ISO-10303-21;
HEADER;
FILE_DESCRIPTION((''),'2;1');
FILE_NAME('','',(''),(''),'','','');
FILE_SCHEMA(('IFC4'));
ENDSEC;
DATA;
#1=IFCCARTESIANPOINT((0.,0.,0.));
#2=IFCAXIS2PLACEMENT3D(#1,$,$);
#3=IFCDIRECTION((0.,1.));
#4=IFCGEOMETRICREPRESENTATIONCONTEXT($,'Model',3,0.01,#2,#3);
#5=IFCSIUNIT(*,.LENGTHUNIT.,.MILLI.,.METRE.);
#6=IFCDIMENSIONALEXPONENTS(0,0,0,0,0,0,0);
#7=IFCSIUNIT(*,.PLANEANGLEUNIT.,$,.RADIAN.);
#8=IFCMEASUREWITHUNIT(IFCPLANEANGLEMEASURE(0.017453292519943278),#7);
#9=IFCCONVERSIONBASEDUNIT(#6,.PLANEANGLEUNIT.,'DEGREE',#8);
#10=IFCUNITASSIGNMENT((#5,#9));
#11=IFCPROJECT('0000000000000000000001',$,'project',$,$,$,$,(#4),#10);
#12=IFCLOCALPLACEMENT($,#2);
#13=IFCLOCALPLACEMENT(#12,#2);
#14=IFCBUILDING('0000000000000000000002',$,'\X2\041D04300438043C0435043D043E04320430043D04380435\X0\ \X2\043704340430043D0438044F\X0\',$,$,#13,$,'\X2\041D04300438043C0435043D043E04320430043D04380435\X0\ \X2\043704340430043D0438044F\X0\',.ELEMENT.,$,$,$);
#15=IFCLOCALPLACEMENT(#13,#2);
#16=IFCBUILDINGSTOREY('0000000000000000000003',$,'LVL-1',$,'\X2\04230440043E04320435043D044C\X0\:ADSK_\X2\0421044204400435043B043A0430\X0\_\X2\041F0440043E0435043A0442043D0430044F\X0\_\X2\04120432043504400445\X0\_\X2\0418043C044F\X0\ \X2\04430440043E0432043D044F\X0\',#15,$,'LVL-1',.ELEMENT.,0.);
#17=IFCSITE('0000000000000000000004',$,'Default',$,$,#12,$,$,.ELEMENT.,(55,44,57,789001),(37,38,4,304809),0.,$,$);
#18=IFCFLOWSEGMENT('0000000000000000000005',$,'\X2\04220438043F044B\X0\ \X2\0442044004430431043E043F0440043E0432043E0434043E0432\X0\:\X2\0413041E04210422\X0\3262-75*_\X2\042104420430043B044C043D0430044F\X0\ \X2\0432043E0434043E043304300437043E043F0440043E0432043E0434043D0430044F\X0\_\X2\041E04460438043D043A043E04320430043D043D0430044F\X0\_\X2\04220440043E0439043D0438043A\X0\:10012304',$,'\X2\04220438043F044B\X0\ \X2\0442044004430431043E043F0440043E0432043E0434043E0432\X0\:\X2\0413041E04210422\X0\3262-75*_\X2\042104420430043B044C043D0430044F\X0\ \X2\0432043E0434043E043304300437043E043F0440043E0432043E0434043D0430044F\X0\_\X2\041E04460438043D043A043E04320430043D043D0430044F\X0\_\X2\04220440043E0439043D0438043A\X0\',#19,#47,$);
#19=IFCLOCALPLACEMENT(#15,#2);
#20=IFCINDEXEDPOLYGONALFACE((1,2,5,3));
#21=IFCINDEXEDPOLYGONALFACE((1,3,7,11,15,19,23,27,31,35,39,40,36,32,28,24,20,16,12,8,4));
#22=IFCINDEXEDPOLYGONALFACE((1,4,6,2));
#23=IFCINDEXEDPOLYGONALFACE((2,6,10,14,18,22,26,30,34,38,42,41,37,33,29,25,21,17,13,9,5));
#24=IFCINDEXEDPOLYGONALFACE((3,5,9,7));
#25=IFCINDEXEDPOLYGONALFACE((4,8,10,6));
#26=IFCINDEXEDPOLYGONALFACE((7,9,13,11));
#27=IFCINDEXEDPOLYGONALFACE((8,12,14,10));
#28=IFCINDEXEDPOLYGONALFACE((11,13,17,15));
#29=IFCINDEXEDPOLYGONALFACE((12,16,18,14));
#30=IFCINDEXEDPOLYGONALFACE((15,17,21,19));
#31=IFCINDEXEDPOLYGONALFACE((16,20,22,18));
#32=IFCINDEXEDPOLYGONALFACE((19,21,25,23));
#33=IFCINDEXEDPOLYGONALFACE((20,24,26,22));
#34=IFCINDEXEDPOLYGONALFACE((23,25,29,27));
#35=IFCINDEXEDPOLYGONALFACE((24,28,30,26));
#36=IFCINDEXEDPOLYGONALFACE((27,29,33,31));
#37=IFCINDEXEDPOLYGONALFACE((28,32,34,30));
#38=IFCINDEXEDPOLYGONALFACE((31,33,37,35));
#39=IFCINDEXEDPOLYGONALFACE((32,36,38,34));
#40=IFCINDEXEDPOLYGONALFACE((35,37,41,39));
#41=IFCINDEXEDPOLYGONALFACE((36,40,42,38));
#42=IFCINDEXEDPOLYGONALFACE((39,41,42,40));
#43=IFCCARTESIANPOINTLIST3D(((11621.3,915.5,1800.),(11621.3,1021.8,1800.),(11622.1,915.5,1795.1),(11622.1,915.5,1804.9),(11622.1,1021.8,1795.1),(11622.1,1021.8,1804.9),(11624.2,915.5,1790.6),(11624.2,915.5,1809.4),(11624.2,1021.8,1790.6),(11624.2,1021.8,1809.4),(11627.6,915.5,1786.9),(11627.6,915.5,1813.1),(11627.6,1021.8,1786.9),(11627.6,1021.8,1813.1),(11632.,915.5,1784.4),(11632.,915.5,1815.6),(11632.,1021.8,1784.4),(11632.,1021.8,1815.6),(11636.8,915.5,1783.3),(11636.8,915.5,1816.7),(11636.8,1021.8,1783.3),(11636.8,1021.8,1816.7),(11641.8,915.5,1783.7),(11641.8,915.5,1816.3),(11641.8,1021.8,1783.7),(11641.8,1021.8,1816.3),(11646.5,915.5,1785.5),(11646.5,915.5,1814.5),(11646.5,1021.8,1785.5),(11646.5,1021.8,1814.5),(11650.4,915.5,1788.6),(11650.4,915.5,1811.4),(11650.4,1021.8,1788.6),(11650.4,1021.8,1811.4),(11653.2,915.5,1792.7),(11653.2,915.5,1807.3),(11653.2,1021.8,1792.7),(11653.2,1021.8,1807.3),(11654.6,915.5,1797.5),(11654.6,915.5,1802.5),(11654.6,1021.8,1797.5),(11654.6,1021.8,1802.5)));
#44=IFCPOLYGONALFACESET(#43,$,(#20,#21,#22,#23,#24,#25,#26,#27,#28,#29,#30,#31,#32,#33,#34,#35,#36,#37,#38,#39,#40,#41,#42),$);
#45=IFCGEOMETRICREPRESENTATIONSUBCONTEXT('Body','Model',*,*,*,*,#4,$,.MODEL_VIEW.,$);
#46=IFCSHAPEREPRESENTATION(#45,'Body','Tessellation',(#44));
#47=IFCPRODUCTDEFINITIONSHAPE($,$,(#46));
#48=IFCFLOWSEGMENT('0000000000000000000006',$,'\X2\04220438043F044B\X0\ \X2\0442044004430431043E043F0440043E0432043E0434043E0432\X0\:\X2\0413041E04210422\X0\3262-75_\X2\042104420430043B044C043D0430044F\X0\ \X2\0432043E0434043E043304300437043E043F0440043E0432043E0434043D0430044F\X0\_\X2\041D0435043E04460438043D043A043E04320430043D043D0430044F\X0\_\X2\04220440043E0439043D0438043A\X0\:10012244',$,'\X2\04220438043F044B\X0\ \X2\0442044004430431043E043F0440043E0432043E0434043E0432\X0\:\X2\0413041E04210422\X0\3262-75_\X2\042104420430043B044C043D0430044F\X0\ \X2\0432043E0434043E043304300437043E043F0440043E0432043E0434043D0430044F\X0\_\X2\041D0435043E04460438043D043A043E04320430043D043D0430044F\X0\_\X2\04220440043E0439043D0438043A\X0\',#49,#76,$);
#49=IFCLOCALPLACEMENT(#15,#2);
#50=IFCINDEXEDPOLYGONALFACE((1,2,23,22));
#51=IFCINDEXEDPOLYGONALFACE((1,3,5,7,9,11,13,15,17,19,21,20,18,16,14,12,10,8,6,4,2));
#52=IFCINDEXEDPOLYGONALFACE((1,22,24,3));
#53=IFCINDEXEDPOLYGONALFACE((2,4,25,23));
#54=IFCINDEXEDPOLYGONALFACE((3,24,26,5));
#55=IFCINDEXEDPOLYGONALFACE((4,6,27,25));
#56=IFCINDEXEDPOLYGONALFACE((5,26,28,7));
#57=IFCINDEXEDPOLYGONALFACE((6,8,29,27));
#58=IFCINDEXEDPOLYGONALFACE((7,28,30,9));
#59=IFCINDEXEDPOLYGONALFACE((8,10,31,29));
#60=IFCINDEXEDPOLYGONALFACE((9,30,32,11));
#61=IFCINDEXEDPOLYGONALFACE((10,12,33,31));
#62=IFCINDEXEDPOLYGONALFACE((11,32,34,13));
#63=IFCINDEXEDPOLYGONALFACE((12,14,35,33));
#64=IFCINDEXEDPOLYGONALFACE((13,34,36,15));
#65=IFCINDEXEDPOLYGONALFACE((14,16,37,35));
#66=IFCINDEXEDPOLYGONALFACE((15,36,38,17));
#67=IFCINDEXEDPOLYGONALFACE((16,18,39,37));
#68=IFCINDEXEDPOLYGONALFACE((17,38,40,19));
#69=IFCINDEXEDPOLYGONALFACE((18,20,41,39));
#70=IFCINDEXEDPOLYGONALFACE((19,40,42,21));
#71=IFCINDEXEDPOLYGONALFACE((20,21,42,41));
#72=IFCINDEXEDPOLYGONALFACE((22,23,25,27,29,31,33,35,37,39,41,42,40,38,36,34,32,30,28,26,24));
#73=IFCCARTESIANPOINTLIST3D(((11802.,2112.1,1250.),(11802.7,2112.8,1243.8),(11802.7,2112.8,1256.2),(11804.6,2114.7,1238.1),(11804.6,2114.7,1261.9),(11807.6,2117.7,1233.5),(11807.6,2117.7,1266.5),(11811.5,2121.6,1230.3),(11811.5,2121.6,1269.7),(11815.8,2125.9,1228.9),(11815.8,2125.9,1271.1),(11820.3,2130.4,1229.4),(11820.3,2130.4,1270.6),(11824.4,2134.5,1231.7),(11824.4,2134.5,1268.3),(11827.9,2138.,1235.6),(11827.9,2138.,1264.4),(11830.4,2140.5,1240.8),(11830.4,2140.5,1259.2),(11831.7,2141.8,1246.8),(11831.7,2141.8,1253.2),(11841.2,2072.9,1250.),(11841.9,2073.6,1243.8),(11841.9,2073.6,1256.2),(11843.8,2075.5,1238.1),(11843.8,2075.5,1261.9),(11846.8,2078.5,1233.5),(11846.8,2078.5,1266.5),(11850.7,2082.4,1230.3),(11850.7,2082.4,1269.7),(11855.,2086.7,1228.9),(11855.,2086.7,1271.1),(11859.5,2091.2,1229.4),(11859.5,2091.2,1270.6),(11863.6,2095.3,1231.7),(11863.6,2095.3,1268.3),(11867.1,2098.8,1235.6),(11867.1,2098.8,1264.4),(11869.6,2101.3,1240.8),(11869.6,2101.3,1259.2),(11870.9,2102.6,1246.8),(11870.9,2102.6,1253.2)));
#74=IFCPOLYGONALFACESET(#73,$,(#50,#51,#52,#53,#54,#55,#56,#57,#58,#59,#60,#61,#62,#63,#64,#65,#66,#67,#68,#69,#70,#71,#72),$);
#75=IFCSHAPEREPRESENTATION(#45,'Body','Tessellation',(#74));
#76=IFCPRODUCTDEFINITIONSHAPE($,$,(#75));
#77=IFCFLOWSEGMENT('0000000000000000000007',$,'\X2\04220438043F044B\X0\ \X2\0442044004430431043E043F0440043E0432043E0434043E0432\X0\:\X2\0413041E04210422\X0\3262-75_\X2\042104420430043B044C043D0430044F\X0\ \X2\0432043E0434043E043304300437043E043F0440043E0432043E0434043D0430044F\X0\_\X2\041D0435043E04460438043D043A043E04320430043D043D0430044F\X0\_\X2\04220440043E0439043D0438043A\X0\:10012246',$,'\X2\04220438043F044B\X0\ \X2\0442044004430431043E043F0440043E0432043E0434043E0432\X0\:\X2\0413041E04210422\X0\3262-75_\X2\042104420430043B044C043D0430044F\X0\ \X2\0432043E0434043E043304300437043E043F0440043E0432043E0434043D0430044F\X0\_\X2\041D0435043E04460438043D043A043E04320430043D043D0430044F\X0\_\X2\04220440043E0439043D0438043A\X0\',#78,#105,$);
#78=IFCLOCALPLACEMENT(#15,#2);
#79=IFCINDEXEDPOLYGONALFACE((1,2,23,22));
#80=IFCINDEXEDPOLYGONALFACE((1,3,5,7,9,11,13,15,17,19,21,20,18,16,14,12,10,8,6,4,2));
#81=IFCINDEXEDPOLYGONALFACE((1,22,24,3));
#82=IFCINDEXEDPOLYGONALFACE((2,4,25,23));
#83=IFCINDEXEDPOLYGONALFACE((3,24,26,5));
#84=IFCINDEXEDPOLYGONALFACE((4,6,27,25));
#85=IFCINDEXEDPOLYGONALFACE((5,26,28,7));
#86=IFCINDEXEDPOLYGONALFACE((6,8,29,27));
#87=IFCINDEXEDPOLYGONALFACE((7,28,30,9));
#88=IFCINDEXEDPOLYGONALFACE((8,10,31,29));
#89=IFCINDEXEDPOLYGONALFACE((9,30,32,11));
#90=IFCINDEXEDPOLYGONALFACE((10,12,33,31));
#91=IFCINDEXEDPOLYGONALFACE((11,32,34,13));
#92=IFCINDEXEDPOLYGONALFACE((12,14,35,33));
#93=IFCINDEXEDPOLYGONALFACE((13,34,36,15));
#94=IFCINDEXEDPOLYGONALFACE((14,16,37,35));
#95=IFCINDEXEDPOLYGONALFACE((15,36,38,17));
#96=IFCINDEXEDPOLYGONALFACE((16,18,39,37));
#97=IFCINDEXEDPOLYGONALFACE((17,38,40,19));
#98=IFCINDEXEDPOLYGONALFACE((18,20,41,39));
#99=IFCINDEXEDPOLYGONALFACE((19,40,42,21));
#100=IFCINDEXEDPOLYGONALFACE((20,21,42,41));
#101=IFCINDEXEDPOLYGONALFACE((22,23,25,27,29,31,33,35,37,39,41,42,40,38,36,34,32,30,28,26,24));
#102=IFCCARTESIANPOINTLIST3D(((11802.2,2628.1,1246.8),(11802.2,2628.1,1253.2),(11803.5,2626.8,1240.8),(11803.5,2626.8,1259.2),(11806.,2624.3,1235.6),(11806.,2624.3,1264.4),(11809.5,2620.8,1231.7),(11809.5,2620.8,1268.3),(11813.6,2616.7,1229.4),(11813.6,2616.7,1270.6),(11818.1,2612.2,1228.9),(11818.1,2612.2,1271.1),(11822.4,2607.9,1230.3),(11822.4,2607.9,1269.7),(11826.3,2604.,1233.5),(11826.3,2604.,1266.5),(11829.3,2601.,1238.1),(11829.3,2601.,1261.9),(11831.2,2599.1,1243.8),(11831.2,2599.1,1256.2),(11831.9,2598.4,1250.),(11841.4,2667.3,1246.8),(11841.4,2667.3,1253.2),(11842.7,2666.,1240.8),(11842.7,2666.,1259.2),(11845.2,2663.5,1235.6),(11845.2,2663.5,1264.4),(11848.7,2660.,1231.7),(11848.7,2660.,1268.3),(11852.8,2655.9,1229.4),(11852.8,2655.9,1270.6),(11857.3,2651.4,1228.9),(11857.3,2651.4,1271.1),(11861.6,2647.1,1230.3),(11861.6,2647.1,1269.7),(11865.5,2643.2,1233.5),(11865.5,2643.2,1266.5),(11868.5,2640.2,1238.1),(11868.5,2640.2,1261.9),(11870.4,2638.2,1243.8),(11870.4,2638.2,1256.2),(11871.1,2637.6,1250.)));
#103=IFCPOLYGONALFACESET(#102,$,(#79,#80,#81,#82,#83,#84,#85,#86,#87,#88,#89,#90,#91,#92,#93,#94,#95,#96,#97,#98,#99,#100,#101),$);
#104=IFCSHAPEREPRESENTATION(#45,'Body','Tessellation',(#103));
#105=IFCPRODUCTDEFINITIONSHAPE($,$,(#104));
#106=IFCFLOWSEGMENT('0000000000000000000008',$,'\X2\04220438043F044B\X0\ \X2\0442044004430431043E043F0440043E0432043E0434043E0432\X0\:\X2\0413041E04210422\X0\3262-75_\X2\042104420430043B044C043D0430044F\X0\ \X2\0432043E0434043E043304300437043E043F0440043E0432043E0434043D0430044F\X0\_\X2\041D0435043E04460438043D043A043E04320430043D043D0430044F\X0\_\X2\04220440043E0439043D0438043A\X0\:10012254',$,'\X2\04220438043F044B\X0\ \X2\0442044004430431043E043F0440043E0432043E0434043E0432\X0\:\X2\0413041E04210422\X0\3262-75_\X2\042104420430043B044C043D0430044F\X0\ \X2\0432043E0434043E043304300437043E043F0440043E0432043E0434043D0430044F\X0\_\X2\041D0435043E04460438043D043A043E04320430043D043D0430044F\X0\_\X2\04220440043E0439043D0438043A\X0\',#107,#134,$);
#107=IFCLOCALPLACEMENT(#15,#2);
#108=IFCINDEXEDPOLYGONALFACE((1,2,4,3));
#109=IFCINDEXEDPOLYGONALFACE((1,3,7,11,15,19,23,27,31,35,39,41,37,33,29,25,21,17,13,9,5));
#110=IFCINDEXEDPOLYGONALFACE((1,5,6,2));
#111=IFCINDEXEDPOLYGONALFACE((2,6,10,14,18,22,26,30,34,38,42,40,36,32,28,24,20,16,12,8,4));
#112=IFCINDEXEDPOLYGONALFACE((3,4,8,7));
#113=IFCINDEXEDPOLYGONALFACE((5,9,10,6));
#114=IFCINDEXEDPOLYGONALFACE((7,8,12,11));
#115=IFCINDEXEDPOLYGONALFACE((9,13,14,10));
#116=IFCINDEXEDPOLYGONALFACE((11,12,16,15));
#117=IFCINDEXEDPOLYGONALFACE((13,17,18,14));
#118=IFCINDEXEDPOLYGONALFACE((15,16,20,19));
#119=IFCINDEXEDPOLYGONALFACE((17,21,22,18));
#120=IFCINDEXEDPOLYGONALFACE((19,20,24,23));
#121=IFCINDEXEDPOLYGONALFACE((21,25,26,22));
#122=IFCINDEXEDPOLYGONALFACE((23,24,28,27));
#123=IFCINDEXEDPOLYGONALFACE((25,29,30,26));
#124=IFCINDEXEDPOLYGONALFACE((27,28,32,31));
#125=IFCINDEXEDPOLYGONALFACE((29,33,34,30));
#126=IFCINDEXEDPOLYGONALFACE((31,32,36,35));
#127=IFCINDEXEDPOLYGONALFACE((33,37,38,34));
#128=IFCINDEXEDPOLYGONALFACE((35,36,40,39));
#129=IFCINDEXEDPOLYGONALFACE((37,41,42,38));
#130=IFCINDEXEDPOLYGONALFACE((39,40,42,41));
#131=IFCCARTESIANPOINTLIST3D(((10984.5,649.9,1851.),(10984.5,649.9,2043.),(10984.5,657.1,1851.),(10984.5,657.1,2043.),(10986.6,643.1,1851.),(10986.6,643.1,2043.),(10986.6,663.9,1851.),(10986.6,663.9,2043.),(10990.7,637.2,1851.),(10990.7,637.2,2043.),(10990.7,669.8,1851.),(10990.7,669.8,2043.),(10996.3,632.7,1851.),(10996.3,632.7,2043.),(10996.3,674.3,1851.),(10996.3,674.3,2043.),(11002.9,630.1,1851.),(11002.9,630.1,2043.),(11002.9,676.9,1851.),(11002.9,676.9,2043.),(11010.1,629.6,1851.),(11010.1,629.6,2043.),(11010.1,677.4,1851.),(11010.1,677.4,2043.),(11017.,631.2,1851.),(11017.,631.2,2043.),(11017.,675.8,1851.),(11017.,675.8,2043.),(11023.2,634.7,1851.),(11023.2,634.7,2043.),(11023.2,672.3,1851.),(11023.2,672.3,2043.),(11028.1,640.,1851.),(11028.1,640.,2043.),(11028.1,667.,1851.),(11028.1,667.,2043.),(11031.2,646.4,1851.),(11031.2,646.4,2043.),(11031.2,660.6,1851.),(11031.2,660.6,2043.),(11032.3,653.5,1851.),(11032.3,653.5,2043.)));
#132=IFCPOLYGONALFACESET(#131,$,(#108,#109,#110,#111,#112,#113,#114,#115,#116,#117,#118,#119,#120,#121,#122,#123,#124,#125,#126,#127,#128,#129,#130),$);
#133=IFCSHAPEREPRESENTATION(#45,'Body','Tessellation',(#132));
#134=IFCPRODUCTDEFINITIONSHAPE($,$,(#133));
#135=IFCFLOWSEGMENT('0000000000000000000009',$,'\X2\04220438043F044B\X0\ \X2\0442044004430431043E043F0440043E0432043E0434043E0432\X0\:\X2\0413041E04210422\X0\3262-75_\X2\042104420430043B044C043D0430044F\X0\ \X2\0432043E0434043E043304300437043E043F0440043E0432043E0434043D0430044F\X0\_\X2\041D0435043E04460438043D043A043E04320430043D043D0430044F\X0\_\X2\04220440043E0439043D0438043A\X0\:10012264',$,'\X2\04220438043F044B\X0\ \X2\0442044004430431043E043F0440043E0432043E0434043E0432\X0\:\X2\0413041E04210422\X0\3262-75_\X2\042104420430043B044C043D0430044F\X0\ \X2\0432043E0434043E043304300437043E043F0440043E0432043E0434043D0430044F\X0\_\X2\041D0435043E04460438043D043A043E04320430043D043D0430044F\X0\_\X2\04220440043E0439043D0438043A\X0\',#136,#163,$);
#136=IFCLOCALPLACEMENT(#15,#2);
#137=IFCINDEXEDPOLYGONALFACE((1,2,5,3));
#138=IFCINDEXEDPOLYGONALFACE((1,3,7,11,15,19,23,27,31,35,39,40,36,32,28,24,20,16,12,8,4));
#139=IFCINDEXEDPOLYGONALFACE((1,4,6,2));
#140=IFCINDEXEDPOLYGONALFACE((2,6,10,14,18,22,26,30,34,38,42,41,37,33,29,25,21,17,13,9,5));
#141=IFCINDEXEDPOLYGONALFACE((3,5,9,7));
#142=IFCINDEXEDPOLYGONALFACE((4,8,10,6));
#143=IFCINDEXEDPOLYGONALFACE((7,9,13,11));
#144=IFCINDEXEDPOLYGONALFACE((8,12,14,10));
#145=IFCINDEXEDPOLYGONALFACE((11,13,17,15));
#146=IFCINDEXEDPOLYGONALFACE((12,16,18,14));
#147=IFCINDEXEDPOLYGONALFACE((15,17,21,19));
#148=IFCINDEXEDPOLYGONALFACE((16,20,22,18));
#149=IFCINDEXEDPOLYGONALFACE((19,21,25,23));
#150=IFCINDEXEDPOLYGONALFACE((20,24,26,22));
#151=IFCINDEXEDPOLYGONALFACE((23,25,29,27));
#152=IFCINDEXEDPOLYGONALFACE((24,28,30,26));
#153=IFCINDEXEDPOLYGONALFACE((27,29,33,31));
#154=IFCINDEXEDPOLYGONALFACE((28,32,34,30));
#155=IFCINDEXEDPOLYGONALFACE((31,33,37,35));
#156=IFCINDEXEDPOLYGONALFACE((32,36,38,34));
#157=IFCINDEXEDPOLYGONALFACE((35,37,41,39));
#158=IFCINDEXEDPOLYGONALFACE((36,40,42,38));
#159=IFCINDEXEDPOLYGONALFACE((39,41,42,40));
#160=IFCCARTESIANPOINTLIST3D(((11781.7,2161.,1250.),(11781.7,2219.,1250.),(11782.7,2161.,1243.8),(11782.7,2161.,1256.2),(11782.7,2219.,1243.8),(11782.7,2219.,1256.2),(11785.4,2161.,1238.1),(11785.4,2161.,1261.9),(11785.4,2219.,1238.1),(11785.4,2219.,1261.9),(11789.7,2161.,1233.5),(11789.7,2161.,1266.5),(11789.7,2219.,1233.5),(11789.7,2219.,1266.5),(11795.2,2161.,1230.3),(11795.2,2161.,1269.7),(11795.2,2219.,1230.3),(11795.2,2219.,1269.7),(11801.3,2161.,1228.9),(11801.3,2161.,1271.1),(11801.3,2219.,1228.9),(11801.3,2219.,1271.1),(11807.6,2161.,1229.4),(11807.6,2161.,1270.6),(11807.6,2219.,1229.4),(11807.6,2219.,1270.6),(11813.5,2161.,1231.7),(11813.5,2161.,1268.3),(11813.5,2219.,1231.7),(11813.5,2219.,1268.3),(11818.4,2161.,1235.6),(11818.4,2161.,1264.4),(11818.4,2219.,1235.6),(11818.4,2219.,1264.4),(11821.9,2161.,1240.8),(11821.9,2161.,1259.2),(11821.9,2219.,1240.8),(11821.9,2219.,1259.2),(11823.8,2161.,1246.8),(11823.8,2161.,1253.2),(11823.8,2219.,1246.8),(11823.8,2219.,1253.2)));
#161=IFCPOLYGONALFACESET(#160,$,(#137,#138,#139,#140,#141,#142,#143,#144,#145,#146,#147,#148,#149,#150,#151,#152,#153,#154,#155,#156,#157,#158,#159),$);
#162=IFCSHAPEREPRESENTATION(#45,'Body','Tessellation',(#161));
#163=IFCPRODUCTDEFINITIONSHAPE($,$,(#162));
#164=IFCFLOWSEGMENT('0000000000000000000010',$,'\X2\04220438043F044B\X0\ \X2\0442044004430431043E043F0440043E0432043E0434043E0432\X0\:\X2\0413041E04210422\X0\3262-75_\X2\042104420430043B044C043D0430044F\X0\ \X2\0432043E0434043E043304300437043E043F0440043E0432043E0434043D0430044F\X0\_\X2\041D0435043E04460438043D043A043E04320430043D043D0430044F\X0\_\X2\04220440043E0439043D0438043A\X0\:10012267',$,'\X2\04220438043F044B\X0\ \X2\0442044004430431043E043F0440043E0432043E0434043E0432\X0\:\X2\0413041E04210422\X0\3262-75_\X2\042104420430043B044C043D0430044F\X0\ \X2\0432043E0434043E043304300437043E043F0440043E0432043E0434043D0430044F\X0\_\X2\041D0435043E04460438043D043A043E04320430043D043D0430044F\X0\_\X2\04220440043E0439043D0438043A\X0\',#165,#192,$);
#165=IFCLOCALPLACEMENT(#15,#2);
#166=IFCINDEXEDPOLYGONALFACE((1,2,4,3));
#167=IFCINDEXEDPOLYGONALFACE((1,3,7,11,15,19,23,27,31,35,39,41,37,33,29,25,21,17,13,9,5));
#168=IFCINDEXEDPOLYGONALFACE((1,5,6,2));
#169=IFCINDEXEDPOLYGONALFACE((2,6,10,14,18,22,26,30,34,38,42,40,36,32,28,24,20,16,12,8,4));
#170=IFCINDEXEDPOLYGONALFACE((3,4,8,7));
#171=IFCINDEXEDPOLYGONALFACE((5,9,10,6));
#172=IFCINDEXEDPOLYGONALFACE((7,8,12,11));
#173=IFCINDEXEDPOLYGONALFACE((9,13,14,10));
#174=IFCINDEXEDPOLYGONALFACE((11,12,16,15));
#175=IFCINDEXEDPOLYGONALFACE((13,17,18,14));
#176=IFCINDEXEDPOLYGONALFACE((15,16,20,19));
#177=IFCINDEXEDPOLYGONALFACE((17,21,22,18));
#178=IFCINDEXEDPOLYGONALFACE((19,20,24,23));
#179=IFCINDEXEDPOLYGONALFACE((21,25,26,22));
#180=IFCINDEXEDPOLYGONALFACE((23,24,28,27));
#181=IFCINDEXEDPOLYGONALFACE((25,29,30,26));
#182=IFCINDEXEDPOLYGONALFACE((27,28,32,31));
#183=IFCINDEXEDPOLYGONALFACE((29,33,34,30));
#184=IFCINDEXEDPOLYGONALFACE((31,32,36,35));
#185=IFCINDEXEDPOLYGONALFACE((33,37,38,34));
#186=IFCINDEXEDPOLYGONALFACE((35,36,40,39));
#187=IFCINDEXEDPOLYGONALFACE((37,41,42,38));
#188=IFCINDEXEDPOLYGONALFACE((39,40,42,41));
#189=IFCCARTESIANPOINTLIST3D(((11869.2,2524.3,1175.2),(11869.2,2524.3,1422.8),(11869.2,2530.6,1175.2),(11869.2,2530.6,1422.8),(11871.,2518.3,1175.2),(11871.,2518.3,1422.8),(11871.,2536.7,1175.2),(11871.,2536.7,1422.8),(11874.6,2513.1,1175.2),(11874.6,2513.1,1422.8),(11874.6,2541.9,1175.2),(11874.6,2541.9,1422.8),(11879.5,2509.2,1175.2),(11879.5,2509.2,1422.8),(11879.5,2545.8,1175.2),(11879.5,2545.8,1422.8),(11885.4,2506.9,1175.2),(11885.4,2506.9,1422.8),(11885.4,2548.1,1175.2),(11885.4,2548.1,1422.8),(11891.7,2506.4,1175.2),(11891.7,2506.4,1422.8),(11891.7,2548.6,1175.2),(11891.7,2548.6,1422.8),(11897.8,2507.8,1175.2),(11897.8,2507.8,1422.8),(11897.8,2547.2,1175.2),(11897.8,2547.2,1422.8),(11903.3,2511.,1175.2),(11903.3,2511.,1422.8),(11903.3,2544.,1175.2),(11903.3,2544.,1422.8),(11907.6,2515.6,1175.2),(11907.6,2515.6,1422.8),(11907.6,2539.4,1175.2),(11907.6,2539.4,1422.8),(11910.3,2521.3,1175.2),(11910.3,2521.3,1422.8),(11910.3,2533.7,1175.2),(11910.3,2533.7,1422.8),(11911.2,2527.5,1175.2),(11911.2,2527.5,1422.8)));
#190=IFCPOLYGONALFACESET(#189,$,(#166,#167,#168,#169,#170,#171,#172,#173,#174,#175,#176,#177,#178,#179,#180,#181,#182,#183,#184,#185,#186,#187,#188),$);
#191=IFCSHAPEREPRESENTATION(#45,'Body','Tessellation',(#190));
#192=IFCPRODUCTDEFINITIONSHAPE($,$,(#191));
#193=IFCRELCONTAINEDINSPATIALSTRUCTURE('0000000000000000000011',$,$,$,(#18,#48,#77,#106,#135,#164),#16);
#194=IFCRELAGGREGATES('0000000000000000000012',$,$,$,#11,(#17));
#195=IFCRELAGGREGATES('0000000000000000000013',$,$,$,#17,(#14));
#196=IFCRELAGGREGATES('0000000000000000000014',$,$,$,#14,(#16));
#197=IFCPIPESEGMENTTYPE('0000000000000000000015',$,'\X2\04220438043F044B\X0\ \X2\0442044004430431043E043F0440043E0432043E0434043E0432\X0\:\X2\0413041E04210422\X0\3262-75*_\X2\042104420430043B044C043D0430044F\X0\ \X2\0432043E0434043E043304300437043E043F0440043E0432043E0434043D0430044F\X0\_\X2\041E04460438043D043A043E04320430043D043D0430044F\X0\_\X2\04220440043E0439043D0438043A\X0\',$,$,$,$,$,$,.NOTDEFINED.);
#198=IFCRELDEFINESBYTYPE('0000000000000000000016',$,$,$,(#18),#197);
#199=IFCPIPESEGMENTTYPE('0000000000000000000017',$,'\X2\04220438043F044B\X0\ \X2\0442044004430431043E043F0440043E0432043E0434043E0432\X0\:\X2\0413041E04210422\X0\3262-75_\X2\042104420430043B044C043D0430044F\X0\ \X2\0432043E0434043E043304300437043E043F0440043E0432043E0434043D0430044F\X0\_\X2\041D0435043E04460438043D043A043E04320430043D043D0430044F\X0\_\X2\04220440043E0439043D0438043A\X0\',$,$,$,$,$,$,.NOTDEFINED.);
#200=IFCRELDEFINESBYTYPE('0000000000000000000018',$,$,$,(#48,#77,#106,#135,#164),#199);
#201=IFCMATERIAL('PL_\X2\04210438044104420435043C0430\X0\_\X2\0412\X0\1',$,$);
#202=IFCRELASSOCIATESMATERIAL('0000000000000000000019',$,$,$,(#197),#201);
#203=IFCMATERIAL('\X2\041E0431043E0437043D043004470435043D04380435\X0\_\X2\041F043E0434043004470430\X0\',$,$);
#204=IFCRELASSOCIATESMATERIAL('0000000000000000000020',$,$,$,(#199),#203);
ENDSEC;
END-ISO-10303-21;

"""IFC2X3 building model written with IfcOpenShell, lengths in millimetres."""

from ifc_helpers import new_model, entity, si_unit, converted_unit, direction, frame, frame_2d, origin, origin_2d_with_axis, place, context, subcontext, project, spatial, circle, extrude, material, type_object, element, save


model = new_model("IFC2X3")

# Units and contexts
model_context = context("Model", 3, precision=0.01, world=origin(), true_north=direction((0.0, 1.0)))
body_context = subcontext(model_context, "Body", "Model", "MODEL_VIEW")
ifc_project = project(units=[si_unit("LENGTHUNIT", "METRE", prefix="MILLI"), converted_unit("PLANEANGLEUNIT", "DEGREE", entity("IfcPlaneAngleMeasure", 0.017453292519943278), si_unit("PLANEANGLEUNIT", "RADIAN"), dimensions=[0, 0, 0, 0, 0, 0, 0])], contexts=[model_context])

# Site, building, storey
site_placement = place(None, origin())
site = spatial("IfcSite", under=ifc_project, at=site_placement, Name="Default", CompositionType="ELEMENT", RefLatitude=(55, 44, 57, 789001), RefLongitude=(37, 38, 4, 304809), RefElevation=0.0)
building_placement = place(site_placement, origin())
building = spatial("IfcBuilding", under=site, at=building_placement, Name="Наименование здания", LongName="Наименование здания", CompositionType="ELEMENT")
storey_placement = place(building_placement, origin())
storey = spatial("IfcBuildingStorey", under=building, at=storey_placement, Name="LVL-1", ObjectType="Уровень:ADSK_Стрелка_Проектная_Вверх_Имя уровня", LongName="LVL-1", CompositionType="ELEMENT", Elevation=0.0)

# Flow segments
ifc_material_1 = material(Name="PL_Система_В1")
pipe_segment_type_1 = type_object("IfcPipeSegmentType", Name="Типы трубопроводов:ГОСТ3262-75*_Стальная водогазопроводная_Оцинкованная_Тройник", PredefinedType="NOTDEFINED", material=ifc_material_1)
flow_segment_1_placement = place(storey_placement, origin())
element("IfcFlowSegment", 1, at=flow_segment_1_placement, inside=storey, type_object=pipe_segment_type_1, Name="Типы трубопроводов:ГОСТ3262-75*_Стальная водогазопроводная_Оцинкованная_Тройник:10012304", ObjectType="Типы трубопроводов:ГОСТ3262-75*_Стальная водогазопроводная_Оцинкованная_Тройник", context=body_context, shape_type="SweptSolid", body=[
    extrude(circle(Radius=16.8, at=origin_2d_with_axis()), frame((11638.1, 915.5, 1800.0), z_axis=(0.0, 1.0, 0.0), x_axis=(-1.0, 0.0, 0.0)), (0.0, 0.0, 1.0), 106.3),
])
ifc_material_2 = material(Name="Обозначение_Подача")
pipe_segment_type_2 = type_object("IfcPipeSegmentType", Name="Типы трубопроводов:ГОСТ3262-75_Стальная водогазопроводная_Неоцинкованная_Тройник", PredefinedType="NOTDEFINED", material=ifc_material_2)
flow_segment_2_placement = place(storey_placement, origin())
element("IfcFlowSegment", 2, at=flow_segment_2_placement, inside=storey, type_object=pipe_segment_type_2, Name="Типы трубопроводов:ГОСТ3262-75_Стальная водогазопроводная_Неоцинкованная_Тройник:10012244", ObjectType="Типы трубопроводов:ГОСТ3262-75_Стальная водогазопроводная_Неоцинкованная_Тройник", context=body_context, shape_type="SweptSolid", body=[
    extrude(circle(Radius=21.1, at=origin_2d_with_axis()), frame((11856.1, 2087.9, 1250.0), z_axis=(-0.707107, 0.707107, 0.0), x_axis=(-0.707107, -0.707107, 0.0)), (0.0, 0.0, 1.0), 55.4),
])
flow_segment_3_placement = place(storey_placement, origin())
element("IfcFlowSegment", 3, at=flow_segment_3_placement, inside=storey, type_object=pipe_segment_type_2, Name="Типы трубопроводов:ГОСТ3262-75_Стальная водогазопроводная_Неоцинкованная_Тройник:10012246", ObjectType="Типы трубопроводов:ГОСТ3262-75_Стальная водогазопроводная_Неоцинкованная_Тройник", context=body_context, shape_type="SweptSolid", body=[
    extrude(circle(Radius=21.1, at=origin_2d_with_axis()), frame((11817.0, 2613.3, 1250.0), z_axis=(0.707107, 0.707107, 0.0), x_axis=(0.707107, -0.707107, 0.0)), (0.0, 0.0, 1.0), 55.4),
])
flow_segment_4_placement = place(storey_placement, origin())
element("IfcFlowSegment", 4, at=flow_segment_4_placement, inside=storey, type_object=pipe_segment_type_2, Name="Типы трубопроводов:ГОСТ3262-75_Стальная водогазопроводная_Неоцинкованная_Тройник:10012254", ObjectType="Типы трубопроводов:ГОСТ3262-75_Стальная водогазопроводная_Неоцинкованная_Тройник", context=body_context, shape_type="SweptSolid", body=[
    extrude(circle(Radius=24.0, at=origin_2d_with_axis()), frame((11008.3, 653.5, 1851.0)), (0.0, 0.0, 1.0), 192.0),
])
flow_segment_5_placement = place(storey_placement, origin())
element("IfcFlowSegment", 5, at=flow_segment_5_placement, inside=storey, type_object=pipe_segment_type_2, Name="Типы трубопроводов:ГОСТ3262-75_Стальная водогазопроводная_Неоцинкованная_Тройник:10012264", ObjectType="Типы трубопроводов:ГОСТ3262-75_Стальная водогазопроводная_Неоцинкованная_Тройник", context=body_context, shape_type="SweptSolid", body=[
    extrude(circle(Radius=21.1, at=frame_2d((0.0, 0.0), x_axis=(1.0, 0.0))), frame((11802.9, 2161.0, 1250.0), z_axis=(0.0, 1.0, 0.0), x_axis=(-1.0, 0.0, 0.0)), (0.0, 0.0, 1.0), 58.0),
])
flow_segment_6_placement = place(storey_placement, origin())
element("IfcFlowSegment", 6, at=flow_segment_6_placement, inside=storey, type_object=pipe_segment_type_2, Name="Типы трубопроводов:ГОСТ3262-75_Стальная водогазопроводная_Неоцинкованная_Тройник:10012267", ObjectType="Типы трубопроводов:ГОСТ3262-75_Стальная водогазопроводная_Неоцинкованная_Тройник", context=body_context, shape_type="SweptSolid", body=[
    extrude(circle(Radius=21.1, at=origin_2d_with_axis()), frame((11890.1, 2527.5, 1175.2)), (0.0, 0.0, 1.0), 247.6),
])

save(model, "model.ifc")
